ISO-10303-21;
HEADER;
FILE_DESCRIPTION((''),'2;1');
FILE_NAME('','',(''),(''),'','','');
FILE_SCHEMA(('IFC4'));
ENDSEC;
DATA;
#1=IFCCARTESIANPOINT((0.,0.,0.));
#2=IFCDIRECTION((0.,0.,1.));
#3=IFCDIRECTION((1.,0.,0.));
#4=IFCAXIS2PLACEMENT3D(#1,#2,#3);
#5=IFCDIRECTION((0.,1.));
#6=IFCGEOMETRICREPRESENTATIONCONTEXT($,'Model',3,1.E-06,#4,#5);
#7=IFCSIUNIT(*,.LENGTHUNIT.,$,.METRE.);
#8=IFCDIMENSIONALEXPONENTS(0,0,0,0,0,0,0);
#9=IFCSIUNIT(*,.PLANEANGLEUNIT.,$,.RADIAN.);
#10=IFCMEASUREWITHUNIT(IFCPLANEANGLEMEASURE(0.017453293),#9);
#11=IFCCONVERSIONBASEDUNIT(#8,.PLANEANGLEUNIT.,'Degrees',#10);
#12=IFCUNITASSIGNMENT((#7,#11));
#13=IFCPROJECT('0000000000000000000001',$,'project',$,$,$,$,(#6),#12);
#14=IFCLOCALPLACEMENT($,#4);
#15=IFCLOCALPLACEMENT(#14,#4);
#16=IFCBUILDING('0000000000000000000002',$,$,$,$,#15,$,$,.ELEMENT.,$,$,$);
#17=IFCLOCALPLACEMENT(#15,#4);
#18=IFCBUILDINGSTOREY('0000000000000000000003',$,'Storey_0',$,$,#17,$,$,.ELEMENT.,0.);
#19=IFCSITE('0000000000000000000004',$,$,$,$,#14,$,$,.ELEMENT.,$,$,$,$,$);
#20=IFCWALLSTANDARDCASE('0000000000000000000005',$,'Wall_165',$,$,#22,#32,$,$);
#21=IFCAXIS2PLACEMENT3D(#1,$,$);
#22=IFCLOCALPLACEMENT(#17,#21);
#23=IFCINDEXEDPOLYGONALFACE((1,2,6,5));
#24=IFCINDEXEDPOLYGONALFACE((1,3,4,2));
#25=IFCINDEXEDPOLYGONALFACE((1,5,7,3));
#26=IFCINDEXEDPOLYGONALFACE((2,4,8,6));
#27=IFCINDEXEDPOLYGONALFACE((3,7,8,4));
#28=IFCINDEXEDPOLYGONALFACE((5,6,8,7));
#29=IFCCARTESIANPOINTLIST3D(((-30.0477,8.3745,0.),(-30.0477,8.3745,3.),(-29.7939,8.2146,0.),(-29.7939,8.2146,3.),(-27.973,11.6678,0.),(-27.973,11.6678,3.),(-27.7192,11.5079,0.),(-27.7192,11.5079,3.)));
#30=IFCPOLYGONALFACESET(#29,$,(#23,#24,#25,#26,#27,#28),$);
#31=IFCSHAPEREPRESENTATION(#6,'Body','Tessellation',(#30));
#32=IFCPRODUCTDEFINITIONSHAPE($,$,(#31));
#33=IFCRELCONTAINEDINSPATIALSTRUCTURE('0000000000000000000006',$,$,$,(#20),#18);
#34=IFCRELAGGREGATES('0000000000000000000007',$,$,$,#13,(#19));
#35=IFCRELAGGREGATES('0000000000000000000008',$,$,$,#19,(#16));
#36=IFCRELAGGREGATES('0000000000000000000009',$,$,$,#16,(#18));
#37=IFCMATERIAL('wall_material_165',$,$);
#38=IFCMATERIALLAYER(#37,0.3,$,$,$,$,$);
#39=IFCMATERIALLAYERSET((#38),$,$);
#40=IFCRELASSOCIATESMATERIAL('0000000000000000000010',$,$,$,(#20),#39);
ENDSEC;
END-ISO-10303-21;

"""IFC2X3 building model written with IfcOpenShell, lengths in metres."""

from ifc_helpers import new_model, entity, si_unit, converted_unit, direction, frame, origin_with_axes, place, context, project, spatial, polyline, outline, extrude, material, layer, layer_set, layer_usage, element, save


model = new_model("IFC2X3")

# Units and contexts
model_context = context("Model", 3, precision=1e-06, world=origin_with_axes(), true_north=direction((0.0, 1.0)))
ifc_project = project(units=[si_unit("LENGTHUNIT", "METRE"), converted_unit("PLANEANGLEUNIT", "Degrees", entity("IfcPlaneAngleMeasure", 0.017453293), si_unit("PLANEANGLEUNIT", "RADIAN"), dimensions=[0, 0, 0, 0, 0, 0, 0])], contexts=[model_context])

# Site, building, storey
site_placement = place(None, origin_with_axes())
site = spatial("IfcSite", under=ifc_project, at=site_placement, CompositionType="ELEMENT")
building_placement = place(site_placement, origin_with_axes())
building = spatial("IfcBuilding", under=site, at=building_placement, CompositionType="ELEMENT")
storey_placement = place(building_placement, origin_with_axes())
storey = spatial("IfcBuildingStorey", under=building, at=storey_placement, Name="Storey_0", CompositionType="ELEMENT", Elevation=0.0)

# Wall
ifc_material_1 = material(Name="wall_material_165")
ifc_layer_1 = layer(ifc_material_1, 0.3)
ifc_layer_set_1 = layer_set([ifc_layer_1])
ifc_layer_usage_1 = layer_usage(ifc_layer_set_1, "AXIS2", "NEGATIVE", 0.0)
wall_1_placement = place(storey_placement, frame((-30.0477, 8.3745, 0.0), z_axis=(0.0, 0.0, 1.0), x_axis=(0.533024, 0.8461, 0.0)))
element("IfcWallStandardCase", 1, at=wall_1_placement, inside=storey, material=ifc_layer_usage_1, Name="Wall_165", context=model_context, shape_type="SweptSolid", body=[
    extrude(outline(polyline([(0.0, 0.0), (3.8924, 0.0), (3.8924, -0.3), (0.0, -0.3), (0.0, 0.0)])), origin_with_axes(), (0.0, 0.0, 1.0), 3.0),
])

save(model, "model.ifc")
